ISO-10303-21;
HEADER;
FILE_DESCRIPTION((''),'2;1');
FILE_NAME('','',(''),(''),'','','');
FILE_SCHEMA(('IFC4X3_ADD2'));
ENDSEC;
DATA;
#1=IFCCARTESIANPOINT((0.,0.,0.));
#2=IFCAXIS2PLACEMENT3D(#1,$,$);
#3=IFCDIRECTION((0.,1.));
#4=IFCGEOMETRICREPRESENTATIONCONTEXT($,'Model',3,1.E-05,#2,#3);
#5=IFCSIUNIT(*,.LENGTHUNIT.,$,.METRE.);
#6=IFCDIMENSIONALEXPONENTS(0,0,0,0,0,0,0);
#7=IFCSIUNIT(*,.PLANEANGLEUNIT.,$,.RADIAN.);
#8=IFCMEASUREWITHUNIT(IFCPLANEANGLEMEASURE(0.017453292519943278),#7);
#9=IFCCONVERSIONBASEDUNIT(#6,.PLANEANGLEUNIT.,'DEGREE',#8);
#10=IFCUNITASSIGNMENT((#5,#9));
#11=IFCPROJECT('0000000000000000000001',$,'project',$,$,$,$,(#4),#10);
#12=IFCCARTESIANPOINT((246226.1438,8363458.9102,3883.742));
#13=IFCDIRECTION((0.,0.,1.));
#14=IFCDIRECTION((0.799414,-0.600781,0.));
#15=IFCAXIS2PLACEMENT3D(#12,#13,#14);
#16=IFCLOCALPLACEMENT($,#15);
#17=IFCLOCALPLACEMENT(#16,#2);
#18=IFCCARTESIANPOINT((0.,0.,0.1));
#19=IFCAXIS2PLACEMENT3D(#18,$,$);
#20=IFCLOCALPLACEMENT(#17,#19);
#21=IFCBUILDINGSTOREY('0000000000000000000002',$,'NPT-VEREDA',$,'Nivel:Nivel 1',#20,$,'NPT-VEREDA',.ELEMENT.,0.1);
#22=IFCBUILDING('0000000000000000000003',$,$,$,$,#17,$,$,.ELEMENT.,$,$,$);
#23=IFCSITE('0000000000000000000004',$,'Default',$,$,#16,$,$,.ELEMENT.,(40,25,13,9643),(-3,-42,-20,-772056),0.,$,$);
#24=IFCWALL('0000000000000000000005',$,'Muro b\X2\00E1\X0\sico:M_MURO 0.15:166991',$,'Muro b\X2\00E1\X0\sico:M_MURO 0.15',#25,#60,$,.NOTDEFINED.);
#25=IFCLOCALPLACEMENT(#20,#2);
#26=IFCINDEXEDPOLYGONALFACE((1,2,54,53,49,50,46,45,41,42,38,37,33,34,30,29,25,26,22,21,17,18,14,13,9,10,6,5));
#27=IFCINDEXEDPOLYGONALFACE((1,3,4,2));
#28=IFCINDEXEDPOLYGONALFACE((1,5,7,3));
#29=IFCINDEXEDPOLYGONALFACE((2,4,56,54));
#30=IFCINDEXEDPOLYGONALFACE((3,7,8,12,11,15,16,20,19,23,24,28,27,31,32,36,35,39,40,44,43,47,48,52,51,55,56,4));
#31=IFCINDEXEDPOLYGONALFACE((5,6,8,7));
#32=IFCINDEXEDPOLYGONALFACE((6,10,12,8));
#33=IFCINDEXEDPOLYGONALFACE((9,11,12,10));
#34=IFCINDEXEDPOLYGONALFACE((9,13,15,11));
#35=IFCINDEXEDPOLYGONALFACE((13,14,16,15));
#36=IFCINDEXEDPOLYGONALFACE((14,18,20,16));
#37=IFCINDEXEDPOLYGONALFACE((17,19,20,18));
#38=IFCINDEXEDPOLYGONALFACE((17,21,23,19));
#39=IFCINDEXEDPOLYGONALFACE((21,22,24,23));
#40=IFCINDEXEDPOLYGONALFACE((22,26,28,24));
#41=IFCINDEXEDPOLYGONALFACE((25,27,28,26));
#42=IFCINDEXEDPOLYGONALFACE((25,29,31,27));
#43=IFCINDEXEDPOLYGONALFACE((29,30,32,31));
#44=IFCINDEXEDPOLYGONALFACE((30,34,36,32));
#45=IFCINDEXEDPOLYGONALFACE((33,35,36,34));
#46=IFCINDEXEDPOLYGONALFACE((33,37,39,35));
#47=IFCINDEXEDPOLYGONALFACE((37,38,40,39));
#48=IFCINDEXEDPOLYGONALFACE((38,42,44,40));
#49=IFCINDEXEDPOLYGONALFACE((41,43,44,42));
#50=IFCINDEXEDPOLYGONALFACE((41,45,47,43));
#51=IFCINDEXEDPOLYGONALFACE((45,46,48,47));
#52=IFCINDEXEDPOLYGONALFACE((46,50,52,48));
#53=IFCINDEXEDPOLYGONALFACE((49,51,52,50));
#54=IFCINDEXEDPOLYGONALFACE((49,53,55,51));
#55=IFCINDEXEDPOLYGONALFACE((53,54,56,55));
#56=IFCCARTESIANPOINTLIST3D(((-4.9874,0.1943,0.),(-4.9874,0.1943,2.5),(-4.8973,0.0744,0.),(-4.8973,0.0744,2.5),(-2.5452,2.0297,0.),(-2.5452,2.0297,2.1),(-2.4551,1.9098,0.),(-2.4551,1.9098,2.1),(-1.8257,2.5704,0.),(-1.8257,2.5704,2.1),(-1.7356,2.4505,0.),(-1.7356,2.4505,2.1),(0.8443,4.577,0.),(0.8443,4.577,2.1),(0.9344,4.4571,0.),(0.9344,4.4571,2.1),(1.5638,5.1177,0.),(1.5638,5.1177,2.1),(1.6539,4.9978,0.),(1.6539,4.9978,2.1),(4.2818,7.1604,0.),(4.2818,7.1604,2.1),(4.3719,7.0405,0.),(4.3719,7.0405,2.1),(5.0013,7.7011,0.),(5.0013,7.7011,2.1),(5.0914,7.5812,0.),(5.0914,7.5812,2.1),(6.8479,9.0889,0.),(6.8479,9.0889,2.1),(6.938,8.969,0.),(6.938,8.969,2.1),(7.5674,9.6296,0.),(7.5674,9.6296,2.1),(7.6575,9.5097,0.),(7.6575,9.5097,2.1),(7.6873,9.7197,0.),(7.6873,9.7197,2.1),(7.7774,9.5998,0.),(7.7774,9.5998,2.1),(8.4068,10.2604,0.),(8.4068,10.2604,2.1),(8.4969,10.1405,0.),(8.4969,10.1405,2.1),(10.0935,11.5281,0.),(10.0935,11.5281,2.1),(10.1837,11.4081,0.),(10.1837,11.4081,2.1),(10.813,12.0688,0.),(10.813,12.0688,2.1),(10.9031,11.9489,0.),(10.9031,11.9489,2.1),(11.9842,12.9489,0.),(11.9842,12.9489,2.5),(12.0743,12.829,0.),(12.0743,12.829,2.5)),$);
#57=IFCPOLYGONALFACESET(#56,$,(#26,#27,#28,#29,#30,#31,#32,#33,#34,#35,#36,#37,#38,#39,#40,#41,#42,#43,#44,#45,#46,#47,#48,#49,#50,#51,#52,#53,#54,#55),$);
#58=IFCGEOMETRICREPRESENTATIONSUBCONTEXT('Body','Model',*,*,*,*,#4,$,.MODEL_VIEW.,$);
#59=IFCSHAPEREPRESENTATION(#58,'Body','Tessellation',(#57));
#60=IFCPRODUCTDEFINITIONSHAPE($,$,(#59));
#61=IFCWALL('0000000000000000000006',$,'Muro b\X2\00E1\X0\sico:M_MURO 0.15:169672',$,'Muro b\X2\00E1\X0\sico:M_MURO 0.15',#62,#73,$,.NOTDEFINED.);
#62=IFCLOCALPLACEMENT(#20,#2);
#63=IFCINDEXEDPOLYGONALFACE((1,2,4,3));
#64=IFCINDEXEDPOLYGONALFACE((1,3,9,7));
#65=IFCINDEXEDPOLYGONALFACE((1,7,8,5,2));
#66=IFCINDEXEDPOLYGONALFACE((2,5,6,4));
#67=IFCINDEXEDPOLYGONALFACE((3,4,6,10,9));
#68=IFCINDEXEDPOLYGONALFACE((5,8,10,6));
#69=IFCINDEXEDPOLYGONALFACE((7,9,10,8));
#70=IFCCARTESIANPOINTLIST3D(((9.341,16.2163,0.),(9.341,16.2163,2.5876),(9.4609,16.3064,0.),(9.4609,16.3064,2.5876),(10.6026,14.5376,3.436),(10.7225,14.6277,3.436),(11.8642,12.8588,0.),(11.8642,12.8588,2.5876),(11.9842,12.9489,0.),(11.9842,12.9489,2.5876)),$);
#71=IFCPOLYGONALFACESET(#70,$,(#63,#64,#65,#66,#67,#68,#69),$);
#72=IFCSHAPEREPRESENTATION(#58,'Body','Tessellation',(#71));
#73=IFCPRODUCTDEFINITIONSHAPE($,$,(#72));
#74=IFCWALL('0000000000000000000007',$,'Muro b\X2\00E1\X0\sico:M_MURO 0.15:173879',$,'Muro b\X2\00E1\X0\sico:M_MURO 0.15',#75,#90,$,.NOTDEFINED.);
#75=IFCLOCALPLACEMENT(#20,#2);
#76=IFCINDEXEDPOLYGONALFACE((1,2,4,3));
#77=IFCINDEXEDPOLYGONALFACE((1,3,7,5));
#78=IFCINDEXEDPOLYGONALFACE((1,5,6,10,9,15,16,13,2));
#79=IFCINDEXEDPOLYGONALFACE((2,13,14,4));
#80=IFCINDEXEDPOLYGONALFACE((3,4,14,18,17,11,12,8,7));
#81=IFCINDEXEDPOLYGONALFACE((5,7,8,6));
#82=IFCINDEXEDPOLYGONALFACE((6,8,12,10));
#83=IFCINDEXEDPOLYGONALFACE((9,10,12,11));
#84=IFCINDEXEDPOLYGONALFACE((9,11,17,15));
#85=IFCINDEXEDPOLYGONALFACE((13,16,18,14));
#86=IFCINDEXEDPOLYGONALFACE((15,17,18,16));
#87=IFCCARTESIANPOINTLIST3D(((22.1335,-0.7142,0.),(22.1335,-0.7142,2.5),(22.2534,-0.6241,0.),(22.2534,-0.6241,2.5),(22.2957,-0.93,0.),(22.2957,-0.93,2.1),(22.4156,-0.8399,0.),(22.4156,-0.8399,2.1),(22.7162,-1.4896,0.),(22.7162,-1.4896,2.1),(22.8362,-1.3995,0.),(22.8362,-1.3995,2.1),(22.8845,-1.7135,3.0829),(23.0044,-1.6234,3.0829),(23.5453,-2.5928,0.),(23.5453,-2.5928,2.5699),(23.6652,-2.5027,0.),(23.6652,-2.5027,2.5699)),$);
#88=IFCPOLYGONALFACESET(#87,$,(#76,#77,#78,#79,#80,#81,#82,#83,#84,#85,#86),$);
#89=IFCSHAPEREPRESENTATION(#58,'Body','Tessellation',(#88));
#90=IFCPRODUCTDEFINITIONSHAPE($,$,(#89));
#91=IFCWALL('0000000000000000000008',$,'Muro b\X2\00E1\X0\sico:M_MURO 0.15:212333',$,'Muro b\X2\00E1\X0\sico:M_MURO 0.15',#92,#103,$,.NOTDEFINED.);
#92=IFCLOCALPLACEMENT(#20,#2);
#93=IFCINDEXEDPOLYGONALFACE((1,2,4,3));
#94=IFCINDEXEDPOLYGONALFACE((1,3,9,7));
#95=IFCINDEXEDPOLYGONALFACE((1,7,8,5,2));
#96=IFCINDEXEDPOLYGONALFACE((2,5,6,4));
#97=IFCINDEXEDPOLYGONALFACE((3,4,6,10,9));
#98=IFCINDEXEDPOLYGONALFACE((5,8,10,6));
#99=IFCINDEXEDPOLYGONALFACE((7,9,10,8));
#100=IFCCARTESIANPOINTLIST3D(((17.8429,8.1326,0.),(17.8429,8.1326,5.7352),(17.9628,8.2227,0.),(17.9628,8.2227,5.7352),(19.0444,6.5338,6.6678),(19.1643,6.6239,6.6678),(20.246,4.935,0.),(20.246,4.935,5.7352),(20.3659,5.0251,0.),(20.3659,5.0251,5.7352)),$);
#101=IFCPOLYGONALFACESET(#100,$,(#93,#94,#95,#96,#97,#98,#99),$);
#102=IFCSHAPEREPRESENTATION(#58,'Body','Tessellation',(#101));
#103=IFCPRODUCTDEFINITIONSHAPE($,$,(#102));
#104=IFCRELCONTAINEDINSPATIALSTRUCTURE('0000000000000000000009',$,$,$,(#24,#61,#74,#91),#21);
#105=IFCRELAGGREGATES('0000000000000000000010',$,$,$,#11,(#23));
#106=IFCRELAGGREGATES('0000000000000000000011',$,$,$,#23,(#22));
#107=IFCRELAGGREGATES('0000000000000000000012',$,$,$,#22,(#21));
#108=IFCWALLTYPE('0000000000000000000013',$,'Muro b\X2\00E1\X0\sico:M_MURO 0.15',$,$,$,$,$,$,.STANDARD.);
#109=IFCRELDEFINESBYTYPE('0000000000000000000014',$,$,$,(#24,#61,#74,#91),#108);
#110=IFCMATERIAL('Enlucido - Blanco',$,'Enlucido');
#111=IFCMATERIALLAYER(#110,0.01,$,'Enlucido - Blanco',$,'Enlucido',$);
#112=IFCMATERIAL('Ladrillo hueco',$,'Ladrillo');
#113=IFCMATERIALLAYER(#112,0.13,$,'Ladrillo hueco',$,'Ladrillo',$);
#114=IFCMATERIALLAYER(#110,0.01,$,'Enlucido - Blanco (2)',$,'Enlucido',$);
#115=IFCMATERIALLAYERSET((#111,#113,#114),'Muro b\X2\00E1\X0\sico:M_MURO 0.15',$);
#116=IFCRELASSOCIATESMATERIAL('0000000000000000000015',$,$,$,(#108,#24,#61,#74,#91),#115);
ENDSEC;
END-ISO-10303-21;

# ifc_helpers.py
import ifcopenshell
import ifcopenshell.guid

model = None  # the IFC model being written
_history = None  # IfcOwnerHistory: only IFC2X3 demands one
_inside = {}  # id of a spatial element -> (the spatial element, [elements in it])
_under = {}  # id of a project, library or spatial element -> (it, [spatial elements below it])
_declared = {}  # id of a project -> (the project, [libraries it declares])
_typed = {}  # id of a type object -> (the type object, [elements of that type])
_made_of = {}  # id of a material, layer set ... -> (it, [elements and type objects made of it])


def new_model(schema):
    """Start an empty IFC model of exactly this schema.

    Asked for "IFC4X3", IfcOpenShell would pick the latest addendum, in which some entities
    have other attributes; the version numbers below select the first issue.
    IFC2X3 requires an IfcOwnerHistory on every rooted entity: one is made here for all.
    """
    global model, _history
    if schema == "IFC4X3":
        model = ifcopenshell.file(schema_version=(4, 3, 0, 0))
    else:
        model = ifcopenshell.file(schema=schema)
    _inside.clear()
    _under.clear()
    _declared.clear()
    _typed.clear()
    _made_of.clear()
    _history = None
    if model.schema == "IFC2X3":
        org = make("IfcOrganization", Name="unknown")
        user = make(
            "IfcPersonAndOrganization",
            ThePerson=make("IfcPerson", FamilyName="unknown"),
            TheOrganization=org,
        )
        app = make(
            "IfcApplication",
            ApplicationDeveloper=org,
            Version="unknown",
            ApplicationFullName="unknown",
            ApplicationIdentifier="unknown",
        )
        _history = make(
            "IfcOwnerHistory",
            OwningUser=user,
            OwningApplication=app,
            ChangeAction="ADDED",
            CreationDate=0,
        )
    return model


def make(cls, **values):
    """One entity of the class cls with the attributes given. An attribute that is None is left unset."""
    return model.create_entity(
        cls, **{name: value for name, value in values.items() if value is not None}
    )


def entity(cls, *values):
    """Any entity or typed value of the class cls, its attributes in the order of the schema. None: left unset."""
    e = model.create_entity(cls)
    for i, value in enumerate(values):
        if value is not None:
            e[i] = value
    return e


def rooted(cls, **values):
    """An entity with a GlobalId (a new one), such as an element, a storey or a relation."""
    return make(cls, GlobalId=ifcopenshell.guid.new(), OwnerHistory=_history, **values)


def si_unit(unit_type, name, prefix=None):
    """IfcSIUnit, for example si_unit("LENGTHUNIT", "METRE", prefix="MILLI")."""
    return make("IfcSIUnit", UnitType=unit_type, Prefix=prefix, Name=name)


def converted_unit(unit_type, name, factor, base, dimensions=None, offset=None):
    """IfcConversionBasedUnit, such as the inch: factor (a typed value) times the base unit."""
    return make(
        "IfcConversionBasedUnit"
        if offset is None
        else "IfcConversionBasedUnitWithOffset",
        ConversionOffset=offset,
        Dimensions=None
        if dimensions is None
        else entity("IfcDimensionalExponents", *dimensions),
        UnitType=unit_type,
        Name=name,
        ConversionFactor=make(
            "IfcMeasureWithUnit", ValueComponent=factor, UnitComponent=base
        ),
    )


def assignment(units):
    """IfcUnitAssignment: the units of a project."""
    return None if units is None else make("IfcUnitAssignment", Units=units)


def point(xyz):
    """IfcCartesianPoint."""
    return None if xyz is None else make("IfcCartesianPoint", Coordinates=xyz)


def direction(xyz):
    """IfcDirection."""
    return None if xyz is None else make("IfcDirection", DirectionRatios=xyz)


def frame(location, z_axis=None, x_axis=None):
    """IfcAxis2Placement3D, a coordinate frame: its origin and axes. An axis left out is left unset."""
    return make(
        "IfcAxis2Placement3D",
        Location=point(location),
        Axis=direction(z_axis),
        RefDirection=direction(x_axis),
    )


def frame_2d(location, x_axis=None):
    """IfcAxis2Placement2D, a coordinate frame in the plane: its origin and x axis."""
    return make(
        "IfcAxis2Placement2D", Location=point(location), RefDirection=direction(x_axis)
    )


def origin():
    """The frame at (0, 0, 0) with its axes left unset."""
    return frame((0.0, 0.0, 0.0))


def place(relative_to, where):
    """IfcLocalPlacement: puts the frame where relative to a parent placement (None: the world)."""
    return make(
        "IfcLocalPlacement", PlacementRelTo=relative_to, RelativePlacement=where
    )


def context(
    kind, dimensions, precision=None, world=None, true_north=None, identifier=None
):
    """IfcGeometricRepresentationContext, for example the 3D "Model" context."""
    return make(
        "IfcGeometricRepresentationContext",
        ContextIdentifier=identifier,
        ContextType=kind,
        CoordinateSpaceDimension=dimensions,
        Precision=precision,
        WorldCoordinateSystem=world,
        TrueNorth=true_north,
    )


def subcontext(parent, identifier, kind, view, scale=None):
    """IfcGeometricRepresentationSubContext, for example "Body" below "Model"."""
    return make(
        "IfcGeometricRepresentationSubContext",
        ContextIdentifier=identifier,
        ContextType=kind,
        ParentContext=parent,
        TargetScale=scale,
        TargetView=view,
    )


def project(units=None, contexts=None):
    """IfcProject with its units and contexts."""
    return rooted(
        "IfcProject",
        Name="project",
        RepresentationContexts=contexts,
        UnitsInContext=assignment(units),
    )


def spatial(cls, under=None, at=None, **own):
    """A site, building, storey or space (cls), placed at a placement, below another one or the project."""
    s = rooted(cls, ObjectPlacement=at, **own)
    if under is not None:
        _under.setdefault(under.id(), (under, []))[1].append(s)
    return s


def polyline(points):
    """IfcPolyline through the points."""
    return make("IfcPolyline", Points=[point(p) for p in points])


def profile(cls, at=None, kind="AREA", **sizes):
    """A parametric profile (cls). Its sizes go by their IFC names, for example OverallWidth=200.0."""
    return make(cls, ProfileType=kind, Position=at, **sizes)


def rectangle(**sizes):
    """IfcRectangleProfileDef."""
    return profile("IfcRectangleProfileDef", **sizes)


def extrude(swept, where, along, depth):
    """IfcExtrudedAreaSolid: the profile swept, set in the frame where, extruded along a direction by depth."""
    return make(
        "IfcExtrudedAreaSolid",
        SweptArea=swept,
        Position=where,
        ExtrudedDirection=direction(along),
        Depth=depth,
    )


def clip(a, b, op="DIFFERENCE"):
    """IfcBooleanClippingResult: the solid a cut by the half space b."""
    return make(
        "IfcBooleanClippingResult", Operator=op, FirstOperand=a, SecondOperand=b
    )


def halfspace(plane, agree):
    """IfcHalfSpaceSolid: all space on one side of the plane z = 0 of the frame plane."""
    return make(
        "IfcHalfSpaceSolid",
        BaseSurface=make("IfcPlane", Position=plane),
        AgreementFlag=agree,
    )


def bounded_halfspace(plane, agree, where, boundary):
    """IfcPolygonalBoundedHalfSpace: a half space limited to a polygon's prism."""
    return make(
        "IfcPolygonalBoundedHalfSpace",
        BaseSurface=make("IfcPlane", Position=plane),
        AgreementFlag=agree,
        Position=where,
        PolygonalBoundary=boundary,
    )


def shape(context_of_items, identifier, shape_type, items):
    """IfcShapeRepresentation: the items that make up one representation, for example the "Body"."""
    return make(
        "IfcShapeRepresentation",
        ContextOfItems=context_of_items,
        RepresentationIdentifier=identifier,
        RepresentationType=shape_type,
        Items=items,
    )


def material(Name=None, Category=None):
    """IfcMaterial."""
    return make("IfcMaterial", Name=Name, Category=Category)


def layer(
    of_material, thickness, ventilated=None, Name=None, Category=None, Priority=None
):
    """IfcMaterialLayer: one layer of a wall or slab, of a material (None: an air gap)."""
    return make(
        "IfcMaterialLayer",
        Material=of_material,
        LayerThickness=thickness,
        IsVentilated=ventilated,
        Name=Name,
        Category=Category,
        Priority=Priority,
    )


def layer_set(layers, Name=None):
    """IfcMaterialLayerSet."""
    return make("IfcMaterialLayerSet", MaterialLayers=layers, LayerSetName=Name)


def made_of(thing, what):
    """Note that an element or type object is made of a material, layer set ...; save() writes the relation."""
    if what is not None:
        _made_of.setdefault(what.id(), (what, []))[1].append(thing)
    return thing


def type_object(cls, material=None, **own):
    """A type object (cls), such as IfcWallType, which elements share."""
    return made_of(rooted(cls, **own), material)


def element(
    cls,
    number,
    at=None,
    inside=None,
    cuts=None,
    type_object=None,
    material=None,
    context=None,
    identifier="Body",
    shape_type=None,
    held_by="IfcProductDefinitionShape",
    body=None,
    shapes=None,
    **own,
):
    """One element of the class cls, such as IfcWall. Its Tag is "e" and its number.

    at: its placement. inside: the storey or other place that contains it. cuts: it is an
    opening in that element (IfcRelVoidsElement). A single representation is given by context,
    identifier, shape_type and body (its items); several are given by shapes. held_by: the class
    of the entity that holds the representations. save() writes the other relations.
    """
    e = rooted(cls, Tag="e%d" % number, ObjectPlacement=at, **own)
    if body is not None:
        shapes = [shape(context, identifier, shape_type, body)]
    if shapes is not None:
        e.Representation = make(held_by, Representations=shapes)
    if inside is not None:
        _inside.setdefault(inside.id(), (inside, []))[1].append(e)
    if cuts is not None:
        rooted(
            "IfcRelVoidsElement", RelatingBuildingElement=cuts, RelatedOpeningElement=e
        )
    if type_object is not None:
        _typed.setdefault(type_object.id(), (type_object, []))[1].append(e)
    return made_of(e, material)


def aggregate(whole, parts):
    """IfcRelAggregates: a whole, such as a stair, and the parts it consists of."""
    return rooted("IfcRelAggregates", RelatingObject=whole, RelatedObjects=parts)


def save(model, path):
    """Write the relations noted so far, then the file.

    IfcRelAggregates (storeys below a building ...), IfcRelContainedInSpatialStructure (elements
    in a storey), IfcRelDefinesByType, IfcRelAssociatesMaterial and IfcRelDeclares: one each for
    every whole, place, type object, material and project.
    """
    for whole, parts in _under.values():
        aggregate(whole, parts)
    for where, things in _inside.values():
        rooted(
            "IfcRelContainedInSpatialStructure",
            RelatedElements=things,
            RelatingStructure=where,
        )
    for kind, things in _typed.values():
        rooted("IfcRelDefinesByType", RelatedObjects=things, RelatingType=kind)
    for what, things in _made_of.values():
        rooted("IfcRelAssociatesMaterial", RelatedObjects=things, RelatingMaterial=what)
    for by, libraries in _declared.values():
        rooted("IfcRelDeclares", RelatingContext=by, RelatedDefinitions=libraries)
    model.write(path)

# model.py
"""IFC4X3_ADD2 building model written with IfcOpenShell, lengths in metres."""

from ifc_helpers import new_model, entity, si_unit, converted_unit, direction, frame, frame_2d, origin, place, context, subcontext, project, spatial, polyline, rectangle, extrude, clip, halfspace, bounded_halfspace, material, layer, layer_set, type_object, element, save


model = new_model("IFC4X3_ADD2")

# Units and contexts
model_context = context("Model", 3, precision=1e-05, world=origin(), true_north=direction((0.0, 1.0)))
body_context = subcontext(model_context, "Body", "Model", "MODEL_VIEW")
ifc_project = project(units=[si_unit("LENGTHUNIT", "METRE"), converted_unit("PLANEANGLEUNIT", "DEGREE", entity("IfcPlaneAngleMeasure", 0.017453292519943278), si_unit("PLANEANGLEUNIT", "RADIAN"), dimensions=[0, 0, 0, 0, 0, 0, 0])], contexts=[model_context])

# Site, building, storey
site_placement = place(None, frame((246226.1438, 8363458.9102, 3883.742), z_axis=(0.0, 0.0, 1.0), x_axis=(0.799414, -0.600781, 0.0)))
site = spatial("IfcSite", under=ifc_project, at=site_placement, Name="Default", CompositionType="ELEMENT", RefLatitude=(40, 25, 13, 9643), RefLongitude=(-3, -42, -20, -772056), RefElevation=0.0)
building_placement = place(site_placement, origin())
building = spatial("IfcBuilding", under=site, at=building_placement, CompositionType="ELEMENT")
storey_placement = place(building_placement, frame((0.0, 0.0, 0.1)))
storey = spatial("IfcBuildingStorey", under=building, at=storey_placement, Name="NPT-VEREDA", ObjectType="Nivel:Nivel 1", LongName="NPT-VEREDA", CompositionType="ELEMENT", Elevation=0.1)

# Wall, openings
ifc_material_1 = material(Name="Enlucido - Blanco", Category="Enlucido")
ifc_layer_1 = layer(ifc_material_1, 0.01, Name="Enlucido - Blanco", Category="Enlucido")
ifc_material_2 = material(Name="Ladrillo hueco", Category="Ladrillo")
ifc_layer_2 = layer(ifc_material_2, 0.13, Name="Ladrillo hueco", Category="Ladrillo")
ifc_layer_3 = layer(ifc_material_1, 0.01, Name="Enlucido - Blanco (2)", Category="Enlucido")
ifc_layer_set = layer_set([ifc_layer_1, ifc_layer_2, ifc_layer_3], Name="Muro básico:M_MURO 0.15")
wall_type = type_object("IfcWallType", Name="Muro básico:M_MURO 0.15", PredefinedType="STANDARD", material=ifc_layer_set)
wall_1_placement = place(storey_placement, frame((12.0292, 12.8889, 0.0), z_axis=(0.0, 0.0, 1.0), x_axis=(-0.799414, -0.60078, 0.0)))
wall_1 = element("IfcWall", 1, at=wall_1_placement, inside=storey, type_object=wall_type, material=ifc_layer_set, Name="Muro básico:M_MURO 0.15:166991", ObjectType="Muro básico:M_MURO 0.15", PredefinedType="NOTDEFINED", context=body_context, shape_type="SweptSolid", body=[
    extrude(rectangle(XDim=21.23, YDim=0.15, at=frame_2d((10.615, 0.0), x_axis=(1.0, 0.0))), origin(), (0.0, 0.0, 1.0), 2.5),
])
opening_1_placement = place(wall_1_placement, frame((18.175, 0.075, 0.0)))
element("IfcOpeningElement", 2, at=opening_1_placement, cuts=wall_1, PredefinedType="OPENING", context=body_context, shape_type="SweptSolid", body=[
    extrude(rectangle(XDim=2.1, YDim=0.9, at=frame_2d((1.05, 0.45), x_axis=(1.0, 0.0))), frame((0.0, 0.0, 0.0), z_axis=(0.0, -1.0, 0.0), x_axis=(0.0, 0.0, 1.0)), (0.0, 0.0, 1.0), 0.15),
])
opening_2_placement = place(wall_1_placement, frame((13.935, 0.075, 0.0)))
element("IfcOpeningElement", 3, at=opening_2_placement, cuts=wall_1, PredefinedType="OPENING", context=body_context, shape_type="SweptSolid", body=[
    extrude(rectangle(XDim=2.1, YDim=0.9, at=frame_2d((1.05, 0.45), x_axis=(1.0, 0.0))), frame((0.0, 0.0, 0.0), z_axis=(0.0, -1.0, 0.0), x_axis=(0.0, 0.0, 1.0)), (0.0, 0.0, 1.0), 0.15),
])
opening_3_placement = place(wall_1_placement, frame((9.635, 0.075, 0.0)))
element("IfcOpeningElement", 4, at=opening_3_placement, cuts=wall_1, PredefinedType="OPENING", context=body_context, shape_type="SweptSolid", body=[
    extrude(rectangle(XDim=2.1, YDim=0.9, at=frame_2d((1.05, 0.45), x_axis=(1.0, 0.0))), frame((0.0, 0.0, 0.0), z_axis=(0.0, -1.0, 0.0), x_axis=(0.0, 0.0, 1.0)), (0.0, 0.0, 1.0), 0.15),
])
opening_4_placement = place(wall_1_placement, frame((6.425, 0.075, 0.0)))
element("IfcOpeningElement", 5, at=opening_4_placement, cuts=wall_1, PredefinedType="OPENING", context=body_context, shape_type="SweptSolid", body=[
    extrude(rectangle(XDim=2.1, YDim=0.9, at=frame_2d((1.05, 0.45), x_axis=(1.0, 0.0))), frame((0.0, 0.0, 0.0), z_axis=(0.0, -1.0, 0.0), x_axis=(0.0, 0.0, 1.0)), (0.0, 0.0, 1.0), 0.15),
])
opening_5_placement = place(wall_1_placement, frame((5.375, 0.075, 0.0)))
element("IfcOpeningElement", 6, at=opening_5_placement, cuts=wall_1, PredefinedType="OPENING", context=body_context, shape_type="SweptSolid", body=[
    extrude(rectangle(XDim=2.1, YDim=0.9, at=frame_2d((1.05, 0.45), x_axis=(1.0, 0.0))), frame((0.0, 0.0, 0.0), z_axis=(0.0, -1.0, 0.0), x_axis=(0.0, 0.0, 1.0)), (0.0, 0.0, 1.0), 0.15),
])
opening_6_placement = place(wall_1_placement, frame((2.365, 0.075, 0.0)))
element("IfcOpeningElement", 7, at=opening_6_placement, cuts=wall_1, PredefinedType="OPENING", context=body_context, shape_type="SweptSolid", body=[
    extrude(rectangle(XDim=2.1, YDim=0.9, at=frame_2d((1.05, 0.45), x_axis=(1.0, 0.0))), frame((0.0, 0.0, 0.0), z_axis=(0.0, -1.0, 0.0), x_axis=(0.0, 0.0, 1.0)), (0.0, 0.0, 1.0), 0.15),
])

# Wall
wall_2_placement = place(storey_placement, frame((9.4009, 16.2614, 0.0), z_axis=(0.0, 0.0, 1.0), x_axis=(0.60078, -0.799414, 0.0)))
element("IfcWall", 8, at=wall_2_placement, inside=storey, type_object=wall_type, material=ifc_layer_set, Name="Muro básico:M_MURO 0.15:169672", ObjectType="Muro básico:M_MURO 0.15", PredefinedType="NOTDEFINED", context=body_context, shape_type="Clipping", body=[
    clip(clip(extrude(rectangle(XDim=4.2, YDim=0.15, at=frame_2d((2.1, 0.0), x_axis=(-1.0, 0.0))), origin(), (0.0, 0.0, 1.0), 3.436), bounded_halfspace(frame((2.1, -0.075, 3.436), z_axis=(-0.374607, 0.0, -0.927184), x_axis=(0.0, -1.0, 0.0)), True, frame((2.1, -0.075, 3.436)), polyline([(0.0, 0.0), (2.1, 0.0), (2.1, 0.15), (0.0, 0.15), (0.0, 0.0)]))), bounded_halfspace(frame((0.0, -0.075, 2.5876), z_axis=(0.374607, 0.0, -0.927184), x_axis=(0.0, -1.0, 0.0)), True, frame((0.0, -0.075, 2.5876)), polyline([(0.0, 0.0), (2.1, 0.0), (2.1, 0.15), (0.0, 0.15), (0.0, 0.0)]))),
])

# Wall, opening
wall_3_placement = place(storey_placement, frame((23.6053, -2.5478, 0.0), z_axis=(0.0, 0.0, 1.0), x_axis=(-0.60078, 0.799414, 0.0)))
wall_3 = element("IfcWall", 9, at=wall_3_placement, inside=storey, type_object=wall_type, material=ifc_layer_set, Name="Muro básico:M_MURO 0.15:173879", ObjectType="Muro básico:M_MURO 0.15", PredefinedType="NOTDEFINED", context=body_context, shape_type="Clipping", body=[
    clip(clip(extrude(rectangle(XDim=2.35, YDim=0.15, at=frame_2d((1.175, 0.0), x_axis=(-1.0, 0.0))), origin(), (0.0, 0.0, 1.0), 3.0829), bounded_halfspace(frame((0.0, 0.075, 2.5699), z_axis=(0.422618, 0.0, -0.906308), x_axis=(0.0, 1.0, 0.0)), True, frame((0.0, 0.075, 2.5699)), polyline([(0.0, 0.0), (0.0, -0.15), (1.1, -0.15), (1.1, 0.0), (0.0, 0.0)]))), bounded_halfspace(frame((2.35, -0.075, 2.5), z_axis=(-0.422618, 0.0, -0.906308), x_axis=(0.0, 1.0, 0.0)), True, frame((2.35, -0.075, 2.5)), polyline([(0.0, 0.0), (0.0, 0.15), (-1.25, 0.15), (-1.25, 0.0), (0.0, 0.0)]))),
])
opening_7_placement = place(wall_3_placement, frame((2.08, 0.075, 0.0)))
element("IfcOpeningElement", 10, at=opening_7_placement, cuts=wall_3, PredefinedType="OPENING", context=body_context, shape_type="SweptSolid", body=[
    extrude(rectangle(XDim=2.1, YDim=0.7, at=frame_2d((1.05, 0.35), x_axis=(1.0, 0.0))), frame((0.0, 0.0, 0.0), z_axis=(0.0, -1.0, 0.0), x_axis=(0.0, 0.0, 1.0)), (0.0, 0.0, 1.0), 0.15),
])

# Wall
wall_4_placement = place(storey_placement, frame((17.9028, 8.1777, 0.0), z_axis=(0.0, 0.0, 1.0), x_axis=(0.60078, -0.799414, 0.0)))
element("IfcWall", 11, at=wall_4_placement, inside=storey, type_object=wall_type, material=ifc_layer_set, Name="Muro básico:M_MURO 0.15:212333", ObjectType="Muro básico:M_MURO 0.15", PredefinedType="NOTDEFINED", context=body_context, shape_type="Clipping", body=[
    clip(clip(extrude(rectangle(XDim=4.0, YDim=0.15, at=frame_2d((2.0, 0.0), x_axis=(-1.0, 0.0))), origin(), (0.0, 0.0, 1.0), 6.6678), halfspace(frame((0.0, -0.075, 5.7352), z_axis=(-0.422618, 0.0, 0.906308), x_axis=(0.0, 1.0, 0.0)), False)), halfspace(frame((2.0, -0.075, 6.6678), z_axis=(0.422618, 0.0, 0.906308), x_axis=(0.0, 1.0, 0.0)), False)),
])

save(model, "model.ifc")
